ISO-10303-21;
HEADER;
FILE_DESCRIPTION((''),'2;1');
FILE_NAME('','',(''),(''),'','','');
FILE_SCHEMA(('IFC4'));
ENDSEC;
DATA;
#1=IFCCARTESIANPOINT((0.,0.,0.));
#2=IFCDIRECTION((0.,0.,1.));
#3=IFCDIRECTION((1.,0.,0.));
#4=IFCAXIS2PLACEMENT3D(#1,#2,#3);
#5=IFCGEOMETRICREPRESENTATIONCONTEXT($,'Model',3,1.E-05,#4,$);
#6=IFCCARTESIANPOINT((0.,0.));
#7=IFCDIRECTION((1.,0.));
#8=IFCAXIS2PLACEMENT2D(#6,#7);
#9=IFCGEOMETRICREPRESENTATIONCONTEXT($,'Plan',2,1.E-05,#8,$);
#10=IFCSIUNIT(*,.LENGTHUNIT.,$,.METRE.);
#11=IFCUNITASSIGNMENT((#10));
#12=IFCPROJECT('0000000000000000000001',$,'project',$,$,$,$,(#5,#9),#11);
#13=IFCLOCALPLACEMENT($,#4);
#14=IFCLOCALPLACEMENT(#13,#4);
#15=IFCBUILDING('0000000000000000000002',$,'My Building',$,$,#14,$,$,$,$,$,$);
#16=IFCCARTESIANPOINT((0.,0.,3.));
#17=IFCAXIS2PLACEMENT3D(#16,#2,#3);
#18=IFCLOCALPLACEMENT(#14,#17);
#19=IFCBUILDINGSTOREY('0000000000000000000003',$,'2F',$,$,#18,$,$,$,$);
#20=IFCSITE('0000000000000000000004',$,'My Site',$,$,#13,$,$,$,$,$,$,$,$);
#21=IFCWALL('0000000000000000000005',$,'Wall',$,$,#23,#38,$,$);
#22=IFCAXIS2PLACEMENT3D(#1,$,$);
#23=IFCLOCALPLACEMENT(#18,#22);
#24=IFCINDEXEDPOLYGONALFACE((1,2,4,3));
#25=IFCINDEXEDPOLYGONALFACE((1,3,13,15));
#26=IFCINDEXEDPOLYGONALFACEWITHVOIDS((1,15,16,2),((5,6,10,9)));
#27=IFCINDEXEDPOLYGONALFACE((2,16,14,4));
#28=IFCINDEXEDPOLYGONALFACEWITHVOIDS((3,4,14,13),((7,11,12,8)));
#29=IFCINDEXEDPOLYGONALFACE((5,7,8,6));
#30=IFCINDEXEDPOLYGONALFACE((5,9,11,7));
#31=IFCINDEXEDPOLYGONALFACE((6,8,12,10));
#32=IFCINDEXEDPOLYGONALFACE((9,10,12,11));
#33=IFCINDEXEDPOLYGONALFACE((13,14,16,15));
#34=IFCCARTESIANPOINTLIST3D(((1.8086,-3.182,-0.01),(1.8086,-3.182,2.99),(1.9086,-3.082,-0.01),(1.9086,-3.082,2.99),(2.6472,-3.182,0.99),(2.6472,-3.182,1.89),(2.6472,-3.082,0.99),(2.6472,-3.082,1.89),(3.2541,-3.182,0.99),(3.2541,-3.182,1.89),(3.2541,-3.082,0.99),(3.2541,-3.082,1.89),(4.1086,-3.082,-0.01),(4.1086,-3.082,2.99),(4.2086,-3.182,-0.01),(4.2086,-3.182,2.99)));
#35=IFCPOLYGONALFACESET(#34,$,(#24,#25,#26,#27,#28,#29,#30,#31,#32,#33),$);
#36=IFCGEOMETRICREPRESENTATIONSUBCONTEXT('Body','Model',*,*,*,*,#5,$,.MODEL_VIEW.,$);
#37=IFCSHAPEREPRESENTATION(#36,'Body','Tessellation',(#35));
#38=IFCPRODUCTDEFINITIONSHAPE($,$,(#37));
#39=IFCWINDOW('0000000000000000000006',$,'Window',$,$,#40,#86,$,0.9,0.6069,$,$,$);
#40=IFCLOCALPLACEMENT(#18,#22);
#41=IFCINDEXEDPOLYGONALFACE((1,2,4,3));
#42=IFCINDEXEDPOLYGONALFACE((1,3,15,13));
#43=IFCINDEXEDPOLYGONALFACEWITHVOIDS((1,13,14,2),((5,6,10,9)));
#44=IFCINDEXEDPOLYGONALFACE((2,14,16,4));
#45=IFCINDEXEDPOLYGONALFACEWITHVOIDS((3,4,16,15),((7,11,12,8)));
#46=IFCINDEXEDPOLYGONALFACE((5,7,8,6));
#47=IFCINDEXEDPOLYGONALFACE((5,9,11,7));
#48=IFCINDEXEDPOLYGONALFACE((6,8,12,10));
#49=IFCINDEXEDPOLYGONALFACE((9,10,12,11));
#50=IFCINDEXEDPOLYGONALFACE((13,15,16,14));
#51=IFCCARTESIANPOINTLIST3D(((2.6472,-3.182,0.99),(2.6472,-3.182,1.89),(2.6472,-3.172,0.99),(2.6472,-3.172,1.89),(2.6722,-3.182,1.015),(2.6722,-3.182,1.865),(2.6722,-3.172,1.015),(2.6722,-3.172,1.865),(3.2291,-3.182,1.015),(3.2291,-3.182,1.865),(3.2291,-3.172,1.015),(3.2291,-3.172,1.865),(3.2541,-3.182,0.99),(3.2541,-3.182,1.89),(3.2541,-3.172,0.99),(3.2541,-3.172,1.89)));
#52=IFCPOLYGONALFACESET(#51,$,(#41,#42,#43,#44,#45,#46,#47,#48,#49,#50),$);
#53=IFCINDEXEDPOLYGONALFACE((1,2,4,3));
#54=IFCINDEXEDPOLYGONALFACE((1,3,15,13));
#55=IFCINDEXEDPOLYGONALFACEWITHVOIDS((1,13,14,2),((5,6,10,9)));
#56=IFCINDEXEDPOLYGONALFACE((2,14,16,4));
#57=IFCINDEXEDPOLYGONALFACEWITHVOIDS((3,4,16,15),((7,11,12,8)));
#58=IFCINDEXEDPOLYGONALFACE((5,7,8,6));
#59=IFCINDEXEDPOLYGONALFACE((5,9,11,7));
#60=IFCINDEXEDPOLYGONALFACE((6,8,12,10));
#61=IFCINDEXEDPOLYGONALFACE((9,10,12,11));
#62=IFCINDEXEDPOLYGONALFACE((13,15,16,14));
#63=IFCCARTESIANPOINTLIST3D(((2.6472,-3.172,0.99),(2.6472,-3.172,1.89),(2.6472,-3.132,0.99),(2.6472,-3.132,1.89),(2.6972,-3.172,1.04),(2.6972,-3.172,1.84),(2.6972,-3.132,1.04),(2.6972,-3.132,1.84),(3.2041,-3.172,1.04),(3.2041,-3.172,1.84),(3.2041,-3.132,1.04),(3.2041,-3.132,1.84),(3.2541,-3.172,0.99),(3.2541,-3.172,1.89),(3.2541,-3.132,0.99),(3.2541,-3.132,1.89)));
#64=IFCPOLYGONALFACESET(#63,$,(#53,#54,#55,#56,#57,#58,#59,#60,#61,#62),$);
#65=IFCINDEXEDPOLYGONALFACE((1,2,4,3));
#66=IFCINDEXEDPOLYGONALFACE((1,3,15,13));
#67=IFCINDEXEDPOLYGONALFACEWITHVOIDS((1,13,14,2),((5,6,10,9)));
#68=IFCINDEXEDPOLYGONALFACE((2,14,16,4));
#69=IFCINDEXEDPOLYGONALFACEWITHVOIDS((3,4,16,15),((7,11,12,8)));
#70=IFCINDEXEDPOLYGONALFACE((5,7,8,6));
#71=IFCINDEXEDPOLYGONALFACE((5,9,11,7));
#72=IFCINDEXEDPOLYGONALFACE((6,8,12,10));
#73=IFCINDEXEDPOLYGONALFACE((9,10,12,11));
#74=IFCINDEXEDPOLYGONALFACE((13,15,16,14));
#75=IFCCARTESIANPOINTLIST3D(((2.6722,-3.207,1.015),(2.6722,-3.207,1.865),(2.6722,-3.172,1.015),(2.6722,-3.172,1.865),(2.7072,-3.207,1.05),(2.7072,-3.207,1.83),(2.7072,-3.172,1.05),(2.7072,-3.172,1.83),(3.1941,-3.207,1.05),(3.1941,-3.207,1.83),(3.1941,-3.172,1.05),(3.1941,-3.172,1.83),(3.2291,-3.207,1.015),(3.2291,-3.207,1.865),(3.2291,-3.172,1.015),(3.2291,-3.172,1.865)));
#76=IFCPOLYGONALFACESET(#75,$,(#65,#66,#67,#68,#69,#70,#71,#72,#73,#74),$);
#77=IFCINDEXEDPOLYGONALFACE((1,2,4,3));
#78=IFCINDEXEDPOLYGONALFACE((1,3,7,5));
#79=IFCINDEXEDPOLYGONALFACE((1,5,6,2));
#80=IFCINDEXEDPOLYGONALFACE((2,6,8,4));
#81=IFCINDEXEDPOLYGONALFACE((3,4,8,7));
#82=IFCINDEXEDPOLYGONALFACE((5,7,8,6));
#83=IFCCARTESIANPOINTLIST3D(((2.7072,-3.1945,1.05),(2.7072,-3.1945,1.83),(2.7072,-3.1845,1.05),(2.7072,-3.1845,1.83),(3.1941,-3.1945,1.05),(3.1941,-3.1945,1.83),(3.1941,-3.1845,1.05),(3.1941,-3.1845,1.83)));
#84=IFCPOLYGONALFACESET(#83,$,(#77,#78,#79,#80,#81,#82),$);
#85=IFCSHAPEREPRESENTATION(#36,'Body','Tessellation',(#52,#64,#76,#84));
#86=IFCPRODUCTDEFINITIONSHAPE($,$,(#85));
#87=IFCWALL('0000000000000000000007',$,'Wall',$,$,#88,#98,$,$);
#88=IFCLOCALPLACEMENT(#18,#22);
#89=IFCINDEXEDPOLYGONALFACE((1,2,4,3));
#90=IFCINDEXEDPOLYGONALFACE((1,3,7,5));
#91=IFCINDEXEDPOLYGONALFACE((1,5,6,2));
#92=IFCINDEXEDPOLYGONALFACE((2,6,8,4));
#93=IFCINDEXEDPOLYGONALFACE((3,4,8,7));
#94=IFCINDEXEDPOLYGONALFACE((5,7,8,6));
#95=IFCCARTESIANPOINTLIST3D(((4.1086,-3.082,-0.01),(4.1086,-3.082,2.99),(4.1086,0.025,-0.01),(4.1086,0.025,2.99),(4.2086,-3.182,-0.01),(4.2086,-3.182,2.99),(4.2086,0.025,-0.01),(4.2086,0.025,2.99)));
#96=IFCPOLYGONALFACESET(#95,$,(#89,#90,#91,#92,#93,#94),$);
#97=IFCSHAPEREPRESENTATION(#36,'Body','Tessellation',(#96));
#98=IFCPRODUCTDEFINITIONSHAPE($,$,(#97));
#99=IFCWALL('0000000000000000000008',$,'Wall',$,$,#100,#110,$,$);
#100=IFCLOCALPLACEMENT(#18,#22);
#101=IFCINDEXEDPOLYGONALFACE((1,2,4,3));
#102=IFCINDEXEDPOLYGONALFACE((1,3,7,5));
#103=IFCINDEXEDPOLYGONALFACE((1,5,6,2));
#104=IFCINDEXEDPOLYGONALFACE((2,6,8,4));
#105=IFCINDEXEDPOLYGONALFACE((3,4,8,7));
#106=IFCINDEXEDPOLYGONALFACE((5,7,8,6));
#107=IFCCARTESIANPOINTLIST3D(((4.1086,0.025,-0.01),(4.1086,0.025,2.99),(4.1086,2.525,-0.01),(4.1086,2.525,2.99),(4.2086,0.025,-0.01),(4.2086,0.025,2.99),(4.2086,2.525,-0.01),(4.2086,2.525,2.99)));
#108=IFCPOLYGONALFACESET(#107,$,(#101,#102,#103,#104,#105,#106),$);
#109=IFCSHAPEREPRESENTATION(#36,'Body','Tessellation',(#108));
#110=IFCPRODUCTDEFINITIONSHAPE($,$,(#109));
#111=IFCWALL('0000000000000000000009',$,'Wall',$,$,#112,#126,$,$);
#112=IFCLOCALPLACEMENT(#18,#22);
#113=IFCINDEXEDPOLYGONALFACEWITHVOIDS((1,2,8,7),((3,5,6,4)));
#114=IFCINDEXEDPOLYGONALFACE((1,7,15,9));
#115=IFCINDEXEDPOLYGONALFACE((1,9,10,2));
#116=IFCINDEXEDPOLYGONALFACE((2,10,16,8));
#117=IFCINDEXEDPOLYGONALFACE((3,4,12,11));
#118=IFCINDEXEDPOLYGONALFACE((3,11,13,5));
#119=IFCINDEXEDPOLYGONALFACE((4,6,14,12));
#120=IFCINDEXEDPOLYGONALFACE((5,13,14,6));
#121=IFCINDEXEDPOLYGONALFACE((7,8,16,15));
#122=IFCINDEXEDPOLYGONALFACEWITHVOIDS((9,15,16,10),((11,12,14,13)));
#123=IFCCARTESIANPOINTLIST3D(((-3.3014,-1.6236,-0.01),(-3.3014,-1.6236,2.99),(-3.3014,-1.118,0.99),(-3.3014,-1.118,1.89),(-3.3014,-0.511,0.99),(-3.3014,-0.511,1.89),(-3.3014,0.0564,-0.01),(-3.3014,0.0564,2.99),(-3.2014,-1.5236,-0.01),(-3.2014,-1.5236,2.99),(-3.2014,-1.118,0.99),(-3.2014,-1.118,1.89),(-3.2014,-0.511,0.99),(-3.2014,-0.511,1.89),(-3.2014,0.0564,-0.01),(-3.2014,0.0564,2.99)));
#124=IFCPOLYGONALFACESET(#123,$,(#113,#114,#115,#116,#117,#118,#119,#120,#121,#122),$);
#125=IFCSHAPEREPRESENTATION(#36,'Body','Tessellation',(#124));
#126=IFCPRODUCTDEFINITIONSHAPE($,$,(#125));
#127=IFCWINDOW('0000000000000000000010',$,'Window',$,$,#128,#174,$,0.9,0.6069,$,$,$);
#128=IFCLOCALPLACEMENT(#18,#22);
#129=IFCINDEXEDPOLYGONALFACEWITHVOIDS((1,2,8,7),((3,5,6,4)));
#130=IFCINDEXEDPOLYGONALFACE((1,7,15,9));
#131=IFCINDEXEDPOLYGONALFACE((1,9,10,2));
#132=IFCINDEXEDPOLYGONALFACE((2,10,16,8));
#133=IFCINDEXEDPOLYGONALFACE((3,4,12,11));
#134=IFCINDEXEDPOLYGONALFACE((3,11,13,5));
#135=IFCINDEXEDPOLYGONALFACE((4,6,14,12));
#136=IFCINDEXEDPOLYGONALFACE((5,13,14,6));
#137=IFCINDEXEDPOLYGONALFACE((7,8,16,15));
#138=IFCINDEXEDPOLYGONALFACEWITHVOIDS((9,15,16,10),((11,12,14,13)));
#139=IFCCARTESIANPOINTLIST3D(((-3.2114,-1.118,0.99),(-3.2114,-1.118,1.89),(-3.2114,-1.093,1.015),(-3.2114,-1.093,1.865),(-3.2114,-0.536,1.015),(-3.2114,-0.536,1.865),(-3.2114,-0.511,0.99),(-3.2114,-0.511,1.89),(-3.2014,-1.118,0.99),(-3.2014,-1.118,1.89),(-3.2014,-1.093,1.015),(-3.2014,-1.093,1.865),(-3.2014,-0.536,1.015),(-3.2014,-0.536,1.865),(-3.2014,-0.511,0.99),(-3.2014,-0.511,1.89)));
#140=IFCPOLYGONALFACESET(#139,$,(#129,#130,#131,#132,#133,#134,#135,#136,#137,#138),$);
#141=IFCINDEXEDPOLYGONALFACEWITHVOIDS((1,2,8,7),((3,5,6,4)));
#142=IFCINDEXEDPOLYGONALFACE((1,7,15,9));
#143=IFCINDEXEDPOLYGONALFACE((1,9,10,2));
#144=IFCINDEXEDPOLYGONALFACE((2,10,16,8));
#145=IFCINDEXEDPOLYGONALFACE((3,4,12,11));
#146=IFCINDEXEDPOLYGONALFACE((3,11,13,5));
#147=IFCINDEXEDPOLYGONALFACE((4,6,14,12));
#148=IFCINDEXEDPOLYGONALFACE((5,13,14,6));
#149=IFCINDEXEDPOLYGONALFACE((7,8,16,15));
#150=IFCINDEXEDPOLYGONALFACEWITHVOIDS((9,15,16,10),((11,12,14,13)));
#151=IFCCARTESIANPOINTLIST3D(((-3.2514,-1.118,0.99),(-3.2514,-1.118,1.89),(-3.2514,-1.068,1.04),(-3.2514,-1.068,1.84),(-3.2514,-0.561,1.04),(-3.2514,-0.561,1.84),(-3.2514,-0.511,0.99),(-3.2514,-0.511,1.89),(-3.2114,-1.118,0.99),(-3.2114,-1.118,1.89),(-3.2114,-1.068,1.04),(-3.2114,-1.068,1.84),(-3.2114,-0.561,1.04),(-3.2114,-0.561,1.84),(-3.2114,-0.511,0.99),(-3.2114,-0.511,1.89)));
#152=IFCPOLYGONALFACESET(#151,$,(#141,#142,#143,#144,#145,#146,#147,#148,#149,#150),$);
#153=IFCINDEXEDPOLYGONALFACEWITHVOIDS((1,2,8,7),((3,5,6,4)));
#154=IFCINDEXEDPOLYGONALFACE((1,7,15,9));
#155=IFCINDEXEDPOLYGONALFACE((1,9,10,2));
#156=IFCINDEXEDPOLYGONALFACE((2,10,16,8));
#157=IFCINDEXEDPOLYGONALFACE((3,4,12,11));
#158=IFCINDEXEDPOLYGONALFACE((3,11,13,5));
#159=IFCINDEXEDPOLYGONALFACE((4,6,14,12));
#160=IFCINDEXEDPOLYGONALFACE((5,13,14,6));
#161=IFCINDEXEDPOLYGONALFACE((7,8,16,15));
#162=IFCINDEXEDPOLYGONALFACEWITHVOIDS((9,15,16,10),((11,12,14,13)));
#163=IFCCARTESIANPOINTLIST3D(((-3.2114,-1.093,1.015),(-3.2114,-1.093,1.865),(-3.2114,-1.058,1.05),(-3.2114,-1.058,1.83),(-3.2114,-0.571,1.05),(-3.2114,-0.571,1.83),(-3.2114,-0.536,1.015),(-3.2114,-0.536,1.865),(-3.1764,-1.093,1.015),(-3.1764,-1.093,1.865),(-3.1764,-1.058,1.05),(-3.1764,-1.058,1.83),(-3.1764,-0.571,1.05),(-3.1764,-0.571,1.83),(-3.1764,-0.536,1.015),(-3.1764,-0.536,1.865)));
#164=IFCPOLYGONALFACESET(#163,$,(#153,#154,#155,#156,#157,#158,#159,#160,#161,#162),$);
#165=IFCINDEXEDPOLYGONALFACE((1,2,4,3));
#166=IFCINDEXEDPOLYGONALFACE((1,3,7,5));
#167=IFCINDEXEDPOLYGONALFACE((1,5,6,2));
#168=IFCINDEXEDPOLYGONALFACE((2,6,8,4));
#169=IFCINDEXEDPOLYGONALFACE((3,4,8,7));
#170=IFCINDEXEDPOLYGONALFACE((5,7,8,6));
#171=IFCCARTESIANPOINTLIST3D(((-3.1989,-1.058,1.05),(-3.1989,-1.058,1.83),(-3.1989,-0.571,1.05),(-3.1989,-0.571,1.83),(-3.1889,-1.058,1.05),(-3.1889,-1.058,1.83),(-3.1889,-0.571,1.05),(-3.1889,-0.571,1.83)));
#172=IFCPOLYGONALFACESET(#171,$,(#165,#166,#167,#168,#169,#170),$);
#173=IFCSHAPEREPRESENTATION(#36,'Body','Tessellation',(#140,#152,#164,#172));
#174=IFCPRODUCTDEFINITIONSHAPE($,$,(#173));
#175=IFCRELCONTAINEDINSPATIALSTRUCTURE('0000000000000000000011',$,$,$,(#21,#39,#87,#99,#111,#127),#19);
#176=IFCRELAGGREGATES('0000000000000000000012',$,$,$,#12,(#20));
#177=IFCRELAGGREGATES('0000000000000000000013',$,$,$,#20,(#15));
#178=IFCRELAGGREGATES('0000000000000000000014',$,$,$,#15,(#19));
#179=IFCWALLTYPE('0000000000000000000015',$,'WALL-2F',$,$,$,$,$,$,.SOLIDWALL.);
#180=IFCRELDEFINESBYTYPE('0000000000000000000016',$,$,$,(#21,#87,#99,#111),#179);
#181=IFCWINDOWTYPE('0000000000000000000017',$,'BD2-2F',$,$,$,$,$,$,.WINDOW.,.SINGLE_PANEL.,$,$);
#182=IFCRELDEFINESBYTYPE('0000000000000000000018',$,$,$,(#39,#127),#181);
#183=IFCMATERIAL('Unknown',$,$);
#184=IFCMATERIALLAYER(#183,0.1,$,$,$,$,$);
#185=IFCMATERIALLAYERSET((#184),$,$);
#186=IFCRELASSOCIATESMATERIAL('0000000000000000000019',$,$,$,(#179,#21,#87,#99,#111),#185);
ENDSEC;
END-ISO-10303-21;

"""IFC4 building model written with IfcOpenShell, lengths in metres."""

from ifc_helpers import new_model, entity, si_unit, frame, origin_with_axes, origin_2d_with_axis, place, context, subcontext, project, spatial, line, indexed_curve, outline, extrude, shape, source, transform, mapped, material, layer, layer_set, layer_usage, type_object, type_shapes, element, fill, save


model = new_model("IFC4")

# Units and contexts
model_context = context("Model", 3, precision=1e-05, world=origin_with_axes())
plan_context = context("Plan", 2, precision=1e-05, world=origin_2d_with_axis())
body_context_1 = subcontext(model_context, "Body", "Model", "MODEL_VIEW")
body_context_2 = subcontext(plan_context, "Body", "Plan", "PLAN_VIEW")
ifc_project = project(units=[si_unit("LENGTHUNIT", "METRE")], contexts=[model_context, plan_context])

# Site, building, storey
site_placement = place(None, origin_with_axes())
site = spatial("IfcSite", under=ifc_project, at=site_placement, Name="My Site")
building_placement = place(site_placement, origin_with_axes())
building = spatial("IfcBuilding", under=site, at=building_placement, Name="My Building")
storey_placement = place(building_placement, frame((0.0, 0.0, 3.0), z_axis=(0.0, 0.0, 1.0), x_axis=(1.0, 0.0, 0.0)))
storey = spatial("IfcBuildingStorey", under=building, at=storey_placement, Name="2F")

# Shared definitions
ifc_material_1 = material(Name="Unknown")

# Shared definitions
ifc_layer_1 = layer(ifc_material_1, 0.1)
ifc_layer_set_1 = layer_set([ifc_layer_1])
wall_type_1 = type_object("IfcWallType", Name="WALL-2F", PredefinedType="SOLIDWALL", material=ifc_layer_set_1)

# Wall, opening, window
ifc_layer_usage_1 = layer_usage(ifc_layer_set_1, "AXIS2", "POSITIVE", 0.0)
wall_1_placement = place(storey_placement, frame((1.8086, -3.182, -0.01), z_axis=(0.0, 0.0, 1.0), x_axis=(1.0, 0.0, 0.0)))
wall_1 = element("IfcWall", 1, at=wall_1_placement, inside=storey, type_object=wall_type_1, material=ifc_layer_usage_1, Name="Wall", context=body_context_1, shape_type="SweptSolid", body=[
    extrude(outline(indexed_curve([(0.0, 0.0), (0.1, 0.1), (2.3, 0.1), (2.4, 0.0)], segments=[line(1, 2, 3, 4, 1)])), origin_with_axes(), (0.0, 0.0, 1.0), 3.0),
])
shared_shape_1 = source(origin_with_axes(), body_context_1, "Body", "SweptSolid", [
    extrude(outline(indexed_curve([(0.0, 0.0), (0.6069, 0.0), (0.6069, 0.9), (0.0, 0.9)], segments=[line(1, 2, 3, 4, 1)])), frame((0.0, -0.6, 0.0), z_axis=(0.0, -1.0, 0.0), x_axis=(1.0, 0.0, 0.0)), (0.0, 0.0, -1.0), 1.2),
])
opening_1_placement = place(wall_1_placement, frame((1.4455, 0.1, 1.0), z_axis=(0.0, 0.0, 1.0), x_axis=(-1.0, 0.0, 0.0)))
opening_1 = element("IfcOpeningElement", 2, at=opening_1_placement, cuts=wall_1, PredefinedType="OPENING", context=body_context_1, shape_type="MappedRepresentation", body=[
    mapped(shared_shape_1, transform((0.0, 0.0, 0.0), x_axis=(1.0, 0.0, 0.0), y_axis=(0.0, 1.0, 0.0), z_axis=(0.0, 0.0, 1.0), scale=1.0)),
])
window_type = type_object("IfcWindowType", Name="BD2-2F", PartitioningType="SINGLE_PANEL", PredefinedType="WINDOW")
shared_shape_2 = source(origin_with_axes(), body_context_1, "Body", "SweptSolid", [
    extrude(outline(indexed_curve([(0.0, 0.0), (0.6069, 0.0), (0.6069, 0.9), (0.0, 0.9)], segments=[line(1, 2, 3, 4, 1)]), holes=[indexed_curve([(0.025, 0.025), (0.5819, 0.025), (0.5819, 0.875), (0.025, 0.875)], segments=[line(1, 2, 3, 4, 1)])]), frame((0.0, 0.09, 0.0), z_axis=(0.0, -1.0, 0.0), x_axis=(1.0, 0.0, 0.0)), (0.0, 0.0, -1.0), 0.01),
    extrude(outline(indexed_curve([(0.0, 0.0), (0.6069, 0.0), (0.6069, 0.9), (0.0, 0.9)], segments=[line(1, 2, 3, 4, 1)]), holes=[indexed_curve([(0.05, 0.05), (0.5569, 0.05), (0.5569, 0.85), (0.05, 0.85)], segments=[line(1, 2, 3, 4, 1)])]), frame((0.0, 0.05, 0.0), z_axis=(0.0, -1.0, 0.0), x_axis=(1.0, 0.0, 0.0)), (0.0, 0.0, -1.0), 0.04),
    extrude(outline(indexed_curve([(0.0, 0.0), (0.5569, 0.0), (0.5569, 0.85), (0.0, 0.85)], segments=[line(1, 2, 3, 4, 1)]), holes=[indexed_curve([(0.035, 0.035), (0.5219, 0.035), (0.5219, 0.815), (0.035, 0.815)], segments=[line(1, 2, 3, 4, 1)])]), frame((0.025, 0.09, 0.025), z_axis=(0.0, -1.0, 0.0), x_axis=(1.0, 0.0, 0.0)), (0.0, 0.0, -1.0), 0.035),
    extrude(outline(indexed_curve([(0.035, 0.035), (0.5219, 0.035), (0.5219, 0.815), (0.035, 0.815)], segments=[line(1, 2, 3, 4, 1)])), frame((0.025, 0.1025, 0.025), z_axis=(0.0, -1.0, 0.0), x_axis=(1.0, 0.0, 0.0)), (0.0, 0.0, -1.0), 0.01),
])
shared_shape_3 = source(origin_with_axes(), body_context_2, "Body", "Curve2D", [
    entity("IfcIndexedPolyCurve", entity("IfcCartesianPointList2D", [[0.05, 0.05], [0.5569, 0.05]])),
    entity("IfcIndexedPolyCurve", entity("IfcCartesianPointList2D", [[0.0, 0.1], [0.025, 0.1], [0.025, 0.09], [0.05, 0.09], [0.05, 0.05], [0.0, 0.05]]), [entity("IfcLineIndex", [1, 2, 3, 4, 5, 6, 1])]),
    entity("IfcIndexedPolyCurve", entity("IfcCartesianPointList2D", [[0.6069, 0.1], [0.5819, 0.1], [0.5819, 0.09], [0.5569, 0.09], [0.5569, 0.05], [0.6069, 0.05]]), [entity("IfcLineIndex", [1, 2, 3, 4, 5, 6, 1])]),
    entity("IfcIndexedPolyCurve", entity("IfcCartesianPointList2D", [[0.025, 0.09], [0.06, 0.09], [0.06, 0.125], [0.025, 0.125]]), [entity("IfcLineIndex", [1, 2, 3, 4, 1])]),
    entity("IfcIndexedPolyCurve", entity("IfcCartesianPointList2D", [[0.5819, 0.09], [0.5469, 0.09], [0.5469, 0.125], [0.5819, 0.125]]), [entity("IfcLineIndex", [1, 2, 3, 4, 1])]),
    entity("IfcIndexedPolyCurve", entity("IfcCartesianPointList2D", [[0.06, 0.09], [0.5469, 0.09]])),
    entity("IfcIndexedPolyCurve", entity("IfcCartesianPointList2D", [[0.06, 0.125], [0.5469, 0.125]])),
    entity("IfcIndexedPolyCurve", entity("IfcCartesianPointList2D", [[0.06, 0.1075], [0.5469, 0.1075]])),
])
type_shapes(window_type, [shared_shape_2, shared_shape_3])
window_1_placement = place(opening_1_placement, origin_with_axes())
window_1 = element("IfcWindow", 3, at=window_1_placement, inside=storey, type_object=window_type, Name="Window", OverallHeight=0.9, OverallWidth=0.6069, shapes=[
    shape(body_context_1, "Body", "MappedRepresentation", [mapped(shared_shape_2, transform((0.0, 0.0, 0.0), x_axis=(1.0, 0.0, 0.0), y_axis=(0.0, 1.0, 0.0), z_axis=(0.0, 0.0, 1.0), scale=1.0))]),
    shape(body_context_2, "Body", "MappedRepresentation", [mapped(shared_shape_3, transform((0.0, 0.0, 0.0), x_axis=(1.0, 0.0, 0.0), y_axis=(0.0, 1.0, 0.0), z_axis=(0.0, 0.0, 1.0), scale=1.0))]),
])
fill(opening_1, window_1)

# Walls
ifc_layer_usage_2 = layer_usage(ifc_layer_set_1, "AXIS2", "POSITIVE", 0.0)
wall_2_placement = place(storey_placement, frame((4.2086, -3.182, -0.01), z_axis=(0.0, 0.0, 1.0), x_axis=(0.0, 1.0, 0.0)))
element("IfcWall", 4, at=wall_2_placement, inside=storey, type_object=wall_type_1, material=ifc_layer_usage_2, Name="Wall", context=body_context_1, shape_type="SweptSolid", body=[
    extrude(outline(indexed_curve([(0.0, 0.0), (0.1, 0.1), (3.207, 0.1), (3.207, 0.0)], segments=[line(1, 2, 3, 4, 1)])), origin_with_axes(), (0.0, 0.0, 1.0), 3.0),
])
ifc_layer_usage_3 = layer_usage(ifc_layer_set_1, "AXIS2", "POSITIVE", 0.0)
wall_3_placement = place(storey_placement, frame((4.2086, 0.025, -0.01), z_axis=(0.0, 0.0, 1.0), x_axis=(0.0, 1.0, 0.0)))
element("IfcWall", 5, at=wall_3_placement, inside=storey, type_object=wall_type_1, material=ifc_layer_usage_3, Name="Wall", context=body_context_1, shape_type="SweptSolid", body=[
    extrude(outline(indexed_curve([(0.0, 0.0), (0.0, 0.1), (2.5, 0.1), (2.5, 0.0)], segments=[line(1, 2, 3, 4, 1)])), origin_with_axes(), (0.0, 0.0, 1.0), 3.0),
])

# Wall, opening, window
ifc_layer_usage_4 = layer_usage(ifc_layer_set_1, "AXIS2", "POSITIVE", 0.0)
wall_4_placement = place(storey_placement, frame((-3.3014, 0.0564, -0.01), z_axis=(0.0, 0.0, 1.0), x_axis=(0.0, -1.0, 0.0)))
wall_4 = element("IfcWall", 6, at=wall_4_placement, inside=storey, type_object=wall_type_1, material=ifc_layer_usage_4, Name="Wall", context=body_context_1, shape_type="SweptSolid", body=[
    extrude(outline(indexed_curve([(0.0, 0.0), (0.0, 0.1), (1.58, 0.1), (1.68, 0.0)], segments=[line(1, 2, 3, 4, 1)])), origin_with_axes(), (0.0, 0.0, 1.0), 3.0),
])
opening_2_placement = place(wall_4_placement, frame((0.5674, 0.0, 1.0), z_axis=(0.0, 0.0, 1.0), x_axis=(1.0, 0.0, 0.0)))
opening_2 = element("IfcOpeningElement", 7, at=opening_2_placement, cuts=wall_4, PredefinedType="OPENING", context=body_context_1, shape_type="MappedRepresentation", body=[
    mapped(shared_shape_1, transform((0.0, 0.0, 0.0), x_axis=(1.0, 0.0, 0.0), y_axis=(0.0, 1.0, 0.0), z_axis=(0.0, 0.0, 1.0), scale=1.0)),
])
window_2_placement = place(opening_2_placement, frame((0.0, 0.0, 0.0), z_axis=(0.0, 0.0, 1.0), x_axis=(1.0, 0.0, 0.0)))
window_2 = element("IfcWindow", 8, at=window_2_placement, inside=storey, type_object=window_type, Name="Window", OverallHeight=0.9, OverallWidth=0.6069, shapes=[
    shape(body_context_1, "Body", "MappedRepresentation", [mapped(shared_shape_2, transform((0.0, 0.0, 0.0), x_axis=(1.0, 0.0, 0.0), y_axis=(0.0, 1.0, 0.0), z_axis=(0.0, 0.0, 1.0), scale=1.0))]),
    shape(body_context_2, "Body", "MappedRepresentation", [mapped(shared_shape_3, transform((0.0, 0.0, 0.0), x_axis=(1.0, 0.0, 0.0), y_axis=(0.0, 1.0, 0.0), z_axis=(0.0, 0.0, 1.0), scale=1.0))]),
])
fill(opening_2, window_2)

save(model, "model.ifc")
